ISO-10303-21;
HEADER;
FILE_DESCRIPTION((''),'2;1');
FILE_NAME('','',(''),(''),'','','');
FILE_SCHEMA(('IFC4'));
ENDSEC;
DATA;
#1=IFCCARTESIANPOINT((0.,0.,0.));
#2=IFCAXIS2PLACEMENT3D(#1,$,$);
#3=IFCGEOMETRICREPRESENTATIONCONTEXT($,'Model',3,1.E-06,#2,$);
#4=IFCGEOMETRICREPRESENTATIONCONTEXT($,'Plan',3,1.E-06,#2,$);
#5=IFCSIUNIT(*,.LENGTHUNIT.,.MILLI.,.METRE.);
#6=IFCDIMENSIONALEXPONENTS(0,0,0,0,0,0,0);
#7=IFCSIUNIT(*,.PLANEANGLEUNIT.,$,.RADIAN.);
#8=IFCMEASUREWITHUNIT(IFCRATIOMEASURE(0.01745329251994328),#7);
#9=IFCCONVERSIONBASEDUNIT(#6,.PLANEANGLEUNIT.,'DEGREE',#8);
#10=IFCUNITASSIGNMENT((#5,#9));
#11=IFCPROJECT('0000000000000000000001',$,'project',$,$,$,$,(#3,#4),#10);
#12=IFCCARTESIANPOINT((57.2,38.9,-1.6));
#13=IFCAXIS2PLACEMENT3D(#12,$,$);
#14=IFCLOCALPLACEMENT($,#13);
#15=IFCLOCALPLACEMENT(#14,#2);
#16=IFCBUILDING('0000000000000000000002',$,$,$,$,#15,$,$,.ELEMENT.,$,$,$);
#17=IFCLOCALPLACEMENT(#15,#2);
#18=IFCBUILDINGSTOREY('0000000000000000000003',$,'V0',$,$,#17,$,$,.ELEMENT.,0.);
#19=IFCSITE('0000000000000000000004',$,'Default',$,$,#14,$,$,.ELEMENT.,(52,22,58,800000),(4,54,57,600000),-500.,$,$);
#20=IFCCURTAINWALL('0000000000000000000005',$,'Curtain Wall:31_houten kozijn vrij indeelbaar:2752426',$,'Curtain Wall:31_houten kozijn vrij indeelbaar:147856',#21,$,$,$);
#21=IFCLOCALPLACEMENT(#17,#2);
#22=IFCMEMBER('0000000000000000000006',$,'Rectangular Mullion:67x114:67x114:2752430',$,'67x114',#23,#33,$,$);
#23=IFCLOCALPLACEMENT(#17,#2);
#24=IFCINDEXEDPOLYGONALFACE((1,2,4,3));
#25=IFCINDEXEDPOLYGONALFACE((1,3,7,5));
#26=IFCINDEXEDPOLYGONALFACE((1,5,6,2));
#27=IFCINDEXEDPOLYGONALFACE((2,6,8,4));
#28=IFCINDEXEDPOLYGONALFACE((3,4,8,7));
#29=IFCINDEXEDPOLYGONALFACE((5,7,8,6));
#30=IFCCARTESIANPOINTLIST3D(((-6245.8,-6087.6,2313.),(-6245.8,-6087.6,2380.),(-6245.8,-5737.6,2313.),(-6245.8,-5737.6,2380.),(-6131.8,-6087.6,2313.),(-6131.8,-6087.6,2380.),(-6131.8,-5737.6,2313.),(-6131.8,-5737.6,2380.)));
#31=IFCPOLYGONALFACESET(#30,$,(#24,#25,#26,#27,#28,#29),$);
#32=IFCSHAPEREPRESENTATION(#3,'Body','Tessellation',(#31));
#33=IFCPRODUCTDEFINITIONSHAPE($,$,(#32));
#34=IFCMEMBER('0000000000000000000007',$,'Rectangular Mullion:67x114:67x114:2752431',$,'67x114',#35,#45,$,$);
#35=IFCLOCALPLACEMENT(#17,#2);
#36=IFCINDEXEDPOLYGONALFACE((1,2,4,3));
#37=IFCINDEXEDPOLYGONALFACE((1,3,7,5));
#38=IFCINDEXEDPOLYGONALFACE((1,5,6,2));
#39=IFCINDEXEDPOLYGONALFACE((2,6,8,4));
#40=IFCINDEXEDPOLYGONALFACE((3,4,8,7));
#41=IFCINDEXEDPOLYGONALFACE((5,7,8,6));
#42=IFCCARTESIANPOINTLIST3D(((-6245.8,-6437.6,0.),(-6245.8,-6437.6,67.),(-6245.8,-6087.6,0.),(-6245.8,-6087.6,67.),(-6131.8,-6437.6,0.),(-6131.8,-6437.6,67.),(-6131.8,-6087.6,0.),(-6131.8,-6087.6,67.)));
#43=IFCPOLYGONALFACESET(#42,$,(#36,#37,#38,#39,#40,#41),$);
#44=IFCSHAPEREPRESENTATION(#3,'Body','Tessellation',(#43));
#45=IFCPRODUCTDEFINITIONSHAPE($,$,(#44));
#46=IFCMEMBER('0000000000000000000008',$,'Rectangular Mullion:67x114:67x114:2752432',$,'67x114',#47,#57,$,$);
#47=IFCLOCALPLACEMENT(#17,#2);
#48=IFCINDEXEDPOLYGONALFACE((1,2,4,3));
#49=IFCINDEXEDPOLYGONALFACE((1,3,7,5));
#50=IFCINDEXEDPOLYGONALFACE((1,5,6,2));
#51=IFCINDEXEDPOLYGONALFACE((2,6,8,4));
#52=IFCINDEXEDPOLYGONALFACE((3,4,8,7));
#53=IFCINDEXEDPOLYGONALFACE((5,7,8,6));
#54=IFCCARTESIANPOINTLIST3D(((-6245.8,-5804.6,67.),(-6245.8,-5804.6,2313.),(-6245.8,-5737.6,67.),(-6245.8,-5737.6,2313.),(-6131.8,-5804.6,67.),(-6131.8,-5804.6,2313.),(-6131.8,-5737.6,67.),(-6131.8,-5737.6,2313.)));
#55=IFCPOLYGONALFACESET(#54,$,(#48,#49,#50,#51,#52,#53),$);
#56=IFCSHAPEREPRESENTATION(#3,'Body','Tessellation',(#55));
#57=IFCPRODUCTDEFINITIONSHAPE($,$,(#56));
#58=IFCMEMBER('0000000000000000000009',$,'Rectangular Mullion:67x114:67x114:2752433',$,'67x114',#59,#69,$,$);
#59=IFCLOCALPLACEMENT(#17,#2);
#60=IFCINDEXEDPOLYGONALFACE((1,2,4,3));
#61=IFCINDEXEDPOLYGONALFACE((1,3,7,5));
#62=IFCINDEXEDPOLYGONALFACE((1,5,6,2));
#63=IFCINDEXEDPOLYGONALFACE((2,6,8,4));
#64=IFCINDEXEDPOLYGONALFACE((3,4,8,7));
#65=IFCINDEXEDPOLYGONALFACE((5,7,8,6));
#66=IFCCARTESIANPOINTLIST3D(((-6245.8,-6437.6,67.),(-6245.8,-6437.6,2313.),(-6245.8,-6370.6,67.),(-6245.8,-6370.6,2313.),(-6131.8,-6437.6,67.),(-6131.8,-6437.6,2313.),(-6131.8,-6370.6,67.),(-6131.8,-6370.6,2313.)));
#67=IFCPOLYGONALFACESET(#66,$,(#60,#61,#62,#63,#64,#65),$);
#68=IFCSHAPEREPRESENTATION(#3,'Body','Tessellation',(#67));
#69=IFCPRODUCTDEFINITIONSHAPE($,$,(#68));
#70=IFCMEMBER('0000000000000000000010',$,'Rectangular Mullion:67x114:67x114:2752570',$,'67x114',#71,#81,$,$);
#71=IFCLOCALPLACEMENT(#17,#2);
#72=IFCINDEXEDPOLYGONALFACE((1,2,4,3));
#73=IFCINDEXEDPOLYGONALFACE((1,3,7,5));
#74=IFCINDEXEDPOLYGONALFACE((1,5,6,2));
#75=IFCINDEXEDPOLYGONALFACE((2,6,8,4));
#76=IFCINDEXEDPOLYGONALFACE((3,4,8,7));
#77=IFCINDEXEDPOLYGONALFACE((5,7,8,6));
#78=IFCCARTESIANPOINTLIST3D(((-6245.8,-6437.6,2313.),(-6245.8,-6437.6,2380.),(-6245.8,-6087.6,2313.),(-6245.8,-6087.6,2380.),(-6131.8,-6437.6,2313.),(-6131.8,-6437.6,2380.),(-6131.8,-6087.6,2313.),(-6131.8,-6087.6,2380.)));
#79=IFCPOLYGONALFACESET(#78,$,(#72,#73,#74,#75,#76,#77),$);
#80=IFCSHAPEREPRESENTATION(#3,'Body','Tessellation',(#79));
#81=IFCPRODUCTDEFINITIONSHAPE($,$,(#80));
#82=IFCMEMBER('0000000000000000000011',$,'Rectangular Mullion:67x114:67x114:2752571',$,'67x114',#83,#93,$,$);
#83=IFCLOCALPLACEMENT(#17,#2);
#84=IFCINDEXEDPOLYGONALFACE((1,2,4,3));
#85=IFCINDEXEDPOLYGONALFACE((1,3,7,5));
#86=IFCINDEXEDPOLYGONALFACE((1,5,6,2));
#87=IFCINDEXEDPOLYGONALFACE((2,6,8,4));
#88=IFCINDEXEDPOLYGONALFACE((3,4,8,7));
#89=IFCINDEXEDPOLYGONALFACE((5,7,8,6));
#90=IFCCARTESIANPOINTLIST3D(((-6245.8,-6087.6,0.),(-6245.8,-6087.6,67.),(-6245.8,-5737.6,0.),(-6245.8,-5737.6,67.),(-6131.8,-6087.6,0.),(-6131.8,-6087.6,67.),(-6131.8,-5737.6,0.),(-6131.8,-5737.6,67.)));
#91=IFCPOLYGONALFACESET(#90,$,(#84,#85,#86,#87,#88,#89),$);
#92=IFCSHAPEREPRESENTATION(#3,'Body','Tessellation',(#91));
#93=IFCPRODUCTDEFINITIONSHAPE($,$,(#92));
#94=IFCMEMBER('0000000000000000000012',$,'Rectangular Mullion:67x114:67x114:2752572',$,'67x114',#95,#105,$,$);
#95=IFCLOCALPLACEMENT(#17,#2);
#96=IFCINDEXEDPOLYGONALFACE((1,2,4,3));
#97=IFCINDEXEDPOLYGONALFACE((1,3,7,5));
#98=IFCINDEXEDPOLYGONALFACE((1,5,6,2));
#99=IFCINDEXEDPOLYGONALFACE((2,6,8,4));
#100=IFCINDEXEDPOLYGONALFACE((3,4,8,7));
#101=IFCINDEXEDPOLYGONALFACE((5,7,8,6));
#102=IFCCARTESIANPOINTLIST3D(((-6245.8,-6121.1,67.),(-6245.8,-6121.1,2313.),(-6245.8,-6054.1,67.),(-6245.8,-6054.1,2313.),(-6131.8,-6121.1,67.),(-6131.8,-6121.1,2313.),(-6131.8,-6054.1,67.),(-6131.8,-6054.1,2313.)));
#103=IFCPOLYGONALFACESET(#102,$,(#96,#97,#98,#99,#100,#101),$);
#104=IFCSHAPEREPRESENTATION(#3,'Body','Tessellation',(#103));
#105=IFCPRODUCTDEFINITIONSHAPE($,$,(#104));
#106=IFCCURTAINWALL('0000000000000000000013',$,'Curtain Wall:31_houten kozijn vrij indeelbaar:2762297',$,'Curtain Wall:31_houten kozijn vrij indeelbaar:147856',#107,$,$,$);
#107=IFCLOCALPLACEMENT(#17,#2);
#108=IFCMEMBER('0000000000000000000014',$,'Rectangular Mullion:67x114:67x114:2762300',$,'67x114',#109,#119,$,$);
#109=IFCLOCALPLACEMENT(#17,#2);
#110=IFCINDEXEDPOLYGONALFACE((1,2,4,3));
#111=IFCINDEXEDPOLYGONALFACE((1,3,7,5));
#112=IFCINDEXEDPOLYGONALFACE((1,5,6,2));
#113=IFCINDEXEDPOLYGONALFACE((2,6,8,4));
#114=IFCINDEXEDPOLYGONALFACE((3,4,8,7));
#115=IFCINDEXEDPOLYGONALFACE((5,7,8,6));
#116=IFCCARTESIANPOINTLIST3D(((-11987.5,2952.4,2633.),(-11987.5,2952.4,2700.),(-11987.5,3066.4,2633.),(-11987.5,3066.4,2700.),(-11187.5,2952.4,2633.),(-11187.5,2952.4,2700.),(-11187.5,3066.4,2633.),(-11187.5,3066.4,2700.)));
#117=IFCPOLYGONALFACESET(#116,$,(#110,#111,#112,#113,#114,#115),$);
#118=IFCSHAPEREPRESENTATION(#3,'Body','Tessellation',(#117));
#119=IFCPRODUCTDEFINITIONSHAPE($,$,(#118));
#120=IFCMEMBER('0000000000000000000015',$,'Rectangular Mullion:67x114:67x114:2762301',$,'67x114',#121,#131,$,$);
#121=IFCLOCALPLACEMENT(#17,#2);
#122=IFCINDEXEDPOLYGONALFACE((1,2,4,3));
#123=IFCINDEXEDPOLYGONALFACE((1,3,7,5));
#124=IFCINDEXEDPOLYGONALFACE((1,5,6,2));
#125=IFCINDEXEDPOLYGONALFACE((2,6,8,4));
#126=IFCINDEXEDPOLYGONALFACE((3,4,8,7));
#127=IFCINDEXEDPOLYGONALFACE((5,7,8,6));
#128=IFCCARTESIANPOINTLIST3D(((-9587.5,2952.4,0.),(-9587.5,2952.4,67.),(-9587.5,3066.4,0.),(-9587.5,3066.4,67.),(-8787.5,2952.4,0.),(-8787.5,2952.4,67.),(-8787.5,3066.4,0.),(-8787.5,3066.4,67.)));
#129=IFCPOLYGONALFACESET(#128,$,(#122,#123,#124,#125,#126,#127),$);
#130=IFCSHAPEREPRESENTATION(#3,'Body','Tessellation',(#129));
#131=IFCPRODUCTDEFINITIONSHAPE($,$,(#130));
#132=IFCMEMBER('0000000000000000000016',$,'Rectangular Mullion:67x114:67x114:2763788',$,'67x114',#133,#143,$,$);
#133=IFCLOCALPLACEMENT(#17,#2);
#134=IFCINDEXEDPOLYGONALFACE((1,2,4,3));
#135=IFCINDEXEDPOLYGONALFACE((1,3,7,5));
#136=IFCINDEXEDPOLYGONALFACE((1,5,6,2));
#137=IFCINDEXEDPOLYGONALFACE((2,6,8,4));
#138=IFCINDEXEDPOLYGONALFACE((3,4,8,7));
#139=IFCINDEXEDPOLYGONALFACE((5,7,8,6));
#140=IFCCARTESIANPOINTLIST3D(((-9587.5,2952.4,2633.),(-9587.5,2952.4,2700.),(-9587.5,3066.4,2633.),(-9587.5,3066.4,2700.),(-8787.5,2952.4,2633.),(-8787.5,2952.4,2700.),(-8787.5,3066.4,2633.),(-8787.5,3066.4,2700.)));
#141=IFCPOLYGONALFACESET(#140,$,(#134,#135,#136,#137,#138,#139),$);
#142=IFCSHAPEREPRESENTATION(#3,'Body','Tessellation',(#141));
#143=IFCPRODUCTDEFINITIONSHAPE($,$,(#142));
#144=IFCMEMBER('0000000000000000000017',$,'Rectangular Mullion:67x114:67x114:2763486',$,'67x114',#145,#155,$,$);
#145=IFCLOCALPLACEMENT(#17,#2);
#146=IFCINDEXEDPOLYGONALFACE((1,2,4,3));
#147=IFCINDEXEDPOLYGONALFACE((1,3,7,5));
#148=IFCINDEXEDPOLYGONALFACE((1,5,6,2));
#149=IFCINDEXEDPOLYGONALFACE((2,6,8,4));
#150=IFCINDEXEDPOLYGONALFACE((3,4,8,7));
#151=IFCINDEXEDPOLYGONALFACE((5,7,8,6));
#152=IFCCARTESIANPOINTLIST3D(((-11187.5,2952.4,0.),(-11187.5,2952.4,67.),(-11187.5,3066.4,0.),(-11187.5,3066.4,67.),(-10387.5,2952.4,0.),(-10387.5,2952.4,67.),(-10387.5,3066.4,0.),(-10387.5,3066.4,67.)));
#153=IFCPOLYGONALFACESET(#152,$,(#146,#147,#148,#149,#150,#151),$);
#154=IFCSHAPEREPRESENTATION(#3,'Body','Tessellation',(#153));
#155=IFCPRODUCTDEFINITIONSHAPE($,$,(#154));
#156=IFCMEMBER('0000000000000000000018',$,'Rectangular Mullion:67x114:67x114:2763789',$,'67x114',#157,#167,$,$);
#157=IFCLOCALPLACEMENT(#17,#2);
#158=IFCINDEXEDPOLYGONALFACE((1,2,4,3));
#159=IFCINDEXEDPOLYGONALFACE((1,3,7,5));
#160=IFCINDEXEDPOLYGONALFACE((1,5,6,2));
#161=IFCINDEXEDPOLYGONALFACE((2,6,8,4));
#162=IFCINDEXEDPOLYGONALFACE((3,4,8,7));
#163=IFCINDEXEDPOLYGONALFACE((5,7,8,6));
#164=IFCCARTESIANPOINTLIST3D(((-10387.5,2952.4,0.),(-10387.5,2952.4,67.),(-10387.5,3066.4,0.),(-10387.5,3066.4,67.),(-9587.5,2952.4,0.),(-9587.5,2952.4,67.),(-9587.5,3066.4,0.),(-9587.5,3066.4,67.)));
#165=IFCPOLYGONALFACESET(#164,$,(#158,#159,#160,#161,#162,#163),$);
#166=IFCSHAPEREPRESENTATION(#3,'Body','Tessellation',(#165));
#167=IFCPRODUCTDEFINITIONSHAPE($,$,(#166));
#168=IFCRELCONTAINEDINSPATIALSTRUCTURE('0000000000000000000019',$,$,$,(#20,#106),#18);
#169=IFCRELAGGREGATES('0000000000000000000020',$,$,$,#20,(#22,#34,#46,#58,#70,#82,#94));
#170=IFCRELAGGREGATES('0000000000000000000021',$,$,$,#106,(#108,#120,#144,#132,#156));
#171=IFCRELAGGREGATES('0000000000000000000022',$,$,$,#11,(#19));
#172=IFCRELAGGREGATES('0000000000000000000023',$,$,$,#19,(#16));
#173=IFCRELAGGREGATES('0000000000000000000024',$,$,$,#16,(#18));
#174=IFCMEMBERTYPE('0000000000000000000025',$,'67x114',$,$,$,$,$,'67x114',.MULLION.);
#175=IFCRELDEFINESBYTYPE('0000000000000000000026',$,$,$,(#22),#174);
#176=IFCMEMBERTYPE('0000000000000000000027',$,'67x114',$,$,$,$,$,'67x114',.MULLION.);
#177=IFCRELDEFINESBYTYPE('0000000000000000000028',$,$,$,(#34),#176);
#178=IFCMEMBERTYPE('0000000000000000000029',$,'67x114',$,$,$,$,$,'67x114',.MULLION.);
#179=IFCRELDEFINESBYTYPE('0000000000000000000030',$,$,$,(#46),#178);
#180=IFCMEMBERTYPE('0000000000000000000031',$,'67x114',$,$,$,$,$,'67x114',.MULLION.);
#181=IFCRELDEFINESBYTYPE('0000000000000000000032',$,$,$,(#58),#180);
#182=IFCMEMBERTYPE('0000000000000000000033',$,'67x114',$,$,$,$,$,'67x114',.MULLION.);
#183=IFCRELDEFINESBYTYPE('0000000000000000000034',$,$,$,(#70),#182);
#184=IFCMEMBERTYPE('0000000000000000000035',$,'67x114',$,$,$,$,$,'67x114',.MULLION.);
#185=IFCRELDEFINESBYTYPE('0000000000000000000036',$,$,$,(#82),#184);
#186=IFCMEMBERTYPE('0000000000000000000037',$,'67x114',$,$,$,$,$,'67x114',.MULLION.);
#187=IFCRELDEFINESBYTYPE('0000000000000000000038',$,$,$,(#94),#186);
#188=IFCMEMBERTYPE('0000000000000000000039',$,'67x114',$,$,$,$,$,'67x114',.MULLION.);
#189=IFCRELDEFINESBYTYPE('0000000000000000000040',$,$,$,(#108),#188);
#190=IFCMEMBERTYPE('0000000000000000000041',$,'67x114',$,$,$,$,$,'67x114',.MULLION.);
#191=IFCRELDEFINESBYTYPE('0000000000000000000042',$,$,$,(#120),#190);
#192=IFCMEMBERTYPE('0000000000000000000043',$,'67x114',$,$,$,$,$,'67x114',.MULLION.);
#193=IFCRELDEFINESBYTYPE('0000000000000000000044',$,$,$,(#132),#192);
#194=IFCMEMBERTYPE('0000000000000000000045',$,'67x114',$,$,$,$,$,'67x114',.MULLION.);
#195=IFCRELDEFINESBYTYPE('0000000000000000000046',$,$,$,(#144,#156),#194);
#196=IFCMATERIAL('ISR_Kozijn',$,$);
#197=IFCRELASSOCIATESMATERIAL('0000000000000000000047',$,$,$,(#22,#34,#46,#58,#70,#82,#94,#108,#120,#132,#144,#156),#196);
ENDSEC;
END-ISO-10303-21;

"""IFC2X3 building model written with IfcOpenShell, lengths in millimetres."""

from ifc_helpers import new_model, entity, si_unit, converted_unit, frame, origin, origin_2d_with_axis, place, context, project, spatial, rectangle, extrude, source, transform, mapped, material, type_object, type_shapes, element, aggregate, save


model = new_model("IFC2X3")

# Units and contexts
model_context = context("Model", 3, precision=1e-06, world=origin())
plan_context = context("Plan", 3, precision=1e-06, world=origin())
ifc_project = project(units=[si_unit("LENGTHUNIT", "METRE", prefix="MILLI"), converted_unit("PLANEANGLEUNIT", "DEGREE", entity("IfcRatioMeasure", 0.01745329251994328), si_unit("PLANEANGLEUNIT", "RADIAN"), dimensions=[0, 0, 0, 0, 0, 0, 0])], contexts=[model_context, plan_context])

# Site, building, storey
site_placement = place(None, frame((57.2, 38.9, -1.6)))
site = spatial("IfcSite", under=ifc_project, at=site_placement, Name="Default", CompositionType="ELEMENT", RefLatitude=(52, 22, 58, 800000), RefLongitude=(4, 54, 57, 600000), RefElevation=-500.0)
building_placement = place(site_placement, origin())
building = spatial("IfcBuilding", under=site, at=building_placement, CompositionType="ELEMENT")
storey_placement = place(building_placement, origin())
storey = spatial("IfcBuildingStorey", under=building, at=storey_placement, Name="V0", CompositionType="ELEMENT", Elevation=0.0)

# Curtain walls, members
curtain_wall_1_placement = place(storey_placement, origin())
curtain_wall_1 = element("IfcCurtainWall", 1, at=curtain_wall_1_placement, inside=storey, Name="Curtain Wall:31_houten kozijn vrij indeelbaar:2752426", ObjectType="Curtain Wall:31_houten kozijn vrij indeelbaar:147856")
ifc_material_1 = material(Name="ISR_Kozijn")
member_type_1 = type_object("IfcMemberType", Name="67x114", ElementType="67x114", PredefinedType="MULLION")
shared_shape_1 = source(origin(), model_context, "Body", "SweptSolid", [
    extrude(rectangle(XDim=67.0, YDim=114.0, at=origin_2d_with_axis()), frame((-33.5, 57.0, -350.0), z_axis=(0.0, 0.0, 1.0), x_axis=(-1.0, 0.0, 0.0)), (0.0, 0.0, 1.0), 350.0),
])
type_shapes(member_type_1, [shared_shape_1])
placement_1 = place(building_placement, frame((0.0, 0.0, 625.0)))
member_1_placement = place(placement_1, frame((-6245.8, -5737.6, 1755.0), z_axis=(0.0, 1.0, 0.0), x_axis=(0.0, 0.0, 1.0)))
member_1 = element("IfcMember", 2, at=member_1_placement, type_object=member_type_1, material=ifc_material_1, Name="Rectangular Mullion:67x114:67x114:2752430", ObjectType="67x114", context=model_context, shape_type="MappedRepresentation", body=[
    mapped(shared_shape_1, transform((0.0, 0.0, 0.0), scale=1.0)),
])
member_type_2 = type_object("IfcMemberType", Name="67x114", ElementType="67x114", PredefinedType="MULLION")
shared_shape_2 = source(origin(), model_context, "Body", "SweptSolid", [
    extrude(rectangle(XDim=67.0, YDim=114.0, at=origin_2d_with_axis()), frame((-33.5, 57.0, -350.0), z_axis=(0.0, 0.0, 1.0), x_axis=(-1.0, 0.0, 0.0)), (0.0, 0.0, 1.0), 350.0),
])
type_shapes(member_type_2, [shared_shape_2])
placement_2 = place(building_placement, origin())
member_2_placement = place(placement_2, frame((-6245.8, -6437.6, 0.0), z_axis=(0.0, -1.0, 0.0), x_axis=(0.0, 0.0, -1.0)))
member_2 = element("IfcMember", 3, at=member_2_placement, type_object=member_type_2, material=ifc_material_1, Name="Rectangular Mullion:67x114:67x114:2752431", ObjectType="67x114", context=model_context, shape_type="MappedRepresentation", body=[
    mapped(shared_shape_2, transform((0.0, 0.0, 0.0), scale=1.0)),
])
member_type_3 = type_object("IfcMemberType", Name="67x114", ElementType="67x114", PredefinedType="MULLION")
shared_shape_3 = source(origin(), model_context, "Body", "SweptSolid", [
    extrude(rectangle(XDim=67.0, YDim=114.0, at=origin_2d_with_axis()), frame((-33.5, 57.0, -2246.0), z_axis=(0.0, 0.0, 1.0), x_axis=(-1.0, 0.0, 0.0)), (0.0, 0.0, 1.0), 2246.0),
])
type_shapes(member_type_3, [shared_shape_3])
member_3_placement = place(placement_2, frame((-6245.8, -5737.6, 67.0), z_axis=(0.0, 0.0, -1.0), x_axis=(0.0, 1.0, 0.0)))
member_3 = element("IfcMember", 4, at=member_3_placement, type_object=member_type_3, material=ifc_material_1, Name="Rectangular Mullion:67x114:67x114:2752432", ObjectType="67x114", context=model_context, shape_type="MappedRepresentation", body=[
    mapped(shared_shape_3, transform((0.0, 0.0, 0.0), scale=1.0)),
])
member_type_4 = type_object("IfcMemberType", Name="67x114", ElementType="67x114", PredefinedType="MULLION")
shared_shape_4 = source(origin(), model_context, "Body", "SweptSolid", [
    extrude(rectangle(XDim=67.0, YDim=114.0, at=origin_2d_with_axis()), frame((-33.5, 57.0, -2246.0), z_axis=(0.0, 0.0, 1.0), x_axis=(-1.0, 0.0, 0.0)), (0.0, 0.0, 1.0), 2246.0),
])
type_shapes(member_type_4, [shared_shape_4])
member_4_placement = place(placement_2, frame((-6245.8, -6437.6, 2313.0), z_axis=(0.0, 0.0, 1.0), x_axis=(0.0, -1.0, 0.0)))
member_4 = element("IfcMember", 5, at=member_4_placement, type_object=member_type_4, material=ifc_material_1, Name="Rectangular Mullion:67x114:67x114:2752433", ObjectType="67x114", context=model_context, shape_type="MappedRepresentation", body=[
    mapped(shared_shape_4, transform((0.0, 0.0, 0.0), scale=1.0)),
])
member_type_5 = type_object("IfcMemberType", Name="67x114", ElementType="67x114", PredefinedType="MULLION")
shared_shape_5 = source(origin(), model_context, "Body", "SweptSolid", [
    extrude(rectangle(XDim=67.0, YDim=114.0, at=origin_2d_with_axis()), frame((-33.5, 57.0, -350.0), z_axis=(0.0, 0.0, 1.0), x_axis=(-1.0, 0.0, 0.0)), (0.0, 0.0, 1.0), 350.0),
])
type_shapes(member_type_5, [shared_shape_5])
member_5_placement = place(placement_1, frame((-6245.8, -6087.6, 1755.0), z_axis=(0.0, 1.0, 0.0), x_axis=(0.0, 0.0, 1.0)))
member_5 = element("IfcMember", 6, at=member_5_placement, type_object=member_type_5, material=ifc_material_1, Name="Rectangular Mullion:67x114:67x114:2752570", ObjectType="67x114", context=model_context, shape_type="MappedRepresentation", body=[
    mapped(shared_shape_5, transform((0.0, 0.0, 0.0), scale=1.0)),
])
member_type_6 = type_object("IfcMemberType", Name="67x114", ElementType="67x114", PredefinedType="MULLION")
shared_shape_6 = source(origin(), model_context, "Body", "SweptSolid", [
    extrude(rectangle(XDim=67.0, YDim=114.0, at=origin_2d_with_axis()), frame((-33.5, 57.0, -350.0), z_axis=(0.0, 0.0, 1.0), x_axis=(-1.0, 0.0, 0.0)), (0.0, 0.0, 1.0), 350.0),
])
type_shapes(member_type_6, [shared_shape_6])
member_6_placement = place(placement_2, frame((-6245.8, -6087.6, 0.0), z_axis=(0.0, -1.0, 0.0), x_axis=(0.0, 0.0, -1.0)))
member_6 = element("IfcMember", 7, at=member_6_placement, type_object=member_type_6, material=ifc_material_1, Name="Rectangular Mullion:67x114:67x114:2752571", ObjectType="67x114", context=model_context, shape_type="MappedRepresentation", body=[
    mapped(shared_shape_6, transform((0.0, 0.0, 0.0), scale=1.0)),
])
member_type_7 = type_object("IfcMemberType", Name="67x114", ElementType="67x114", PredefinedType="MULLION")
shared_shape_7 = source(origin(), model_context, "Body", "SweptSolid", [
    extrude(rectangle(XDim=67.0, YDim=114.0, at=origin_2d_with_axis()), frame((0.0, 57.0, -2246.0), z_axis=(0.0, 0.0, 1.0), x_axis=(-1.0, 0.0, 0.0)), (0.0, 0.0, 1.0), 2246.0),
])
type_shapes(member_type_7, [shared_shape_7])
member_7_placement = place(placement_2, frame((-6245.8, -6087.6, 67.0), z_axis=(0.0, 0.0, -1.0), x_axis=(0.0, 1.0, 0.0)))
member_7 = element("IfcMember", 8, at=member_7_placement, type_object=member_type_7, material=ifc_material_1, Name="Rectangular Mullion:67x114:67x114:2752572", ObjectType="67x114", context=model_context, shape_type="MappedRepresentation", body=[
    mapped(shared_shape_7, transform((0.0, 0.0, 0.0), scale=1.0)),
])
curtain_wall_2_placement = place(storey_placement, origin())
curtain_wall_2 = element("IfcCurtainWall", 9, at=curtain_wall_2_placement, inside=storey, Name="Curtain Wall:31_houten kozijn vrij indeelbaar:2762297", ObjectType="Curtain Wall:31_houten kozijn vrij indeelbaar:147856")
member_type_8 = type_object("IfcMemberType", Name="67x114", ElementType="67x114", PredefinedType="MULLION")
shared_shape_8 = source(origin(), model_context, "Body", "SweptSolid", [
    extrude(rectangle(XDim=67.0, YDim=114.0, at=origin_2d_with_axis()), frame((-33.5, 57.0, -800.0), z_axis=(0.0, 0.0, 1.0), x_axis=(-1.0, 0.0, 0.0)), (0.0, 0.0, 1.0), 800.0),
])
type_shapes(member_type_8, [shared_shape_8])
placement_3 = place(building_placement, frame((0.0, 0.0, 2425.0)))
member_8_placement = place(placement_3, frame((-11987.5, 2952.4, 275.0), z_axis=(-1.0, 0.0, 0.0), x_axis=(0.0, 0.0, 1.0)))
member_8 = element("IfcMember", 10, at=member_8_placement, type_object=member_type_8, material=ifc_material_1, Name="Rectangular Mullion:67x114:67x114:2762300", ObjectType="67x114", context=model_context, shape_type="MappedRepresentation", body=[
    mapped(shared_shape_8, transform((0.0, 0.0, 0.0), scale=1.0)),
])
member_type_9 = type_object("IfcMemberType", Name="67x114", ElementType="67x114", PredefinedType="MULLION")
shared_shape_9 = source(origin(), model_context, "Body", "SweptSolid", [
    extrude(rectangle(XDim=67.0, YDim=114.0, at=origin_2d_with_axis()), frame((-33.5, 57.0, -800.0), z_axis=(0.0, 0.0, 1.0), x_axis=(-1.0, 0.0, 0.0)), (0.0, 0.0, 1.0), 800.0),
])
type_shapes(member_type_9, [shared_shape_9])
member_9_placement = place(placement_2, frame((-8787.5, 2952.4, 0.0), z_axis=(1.0, 0.0, 0.0), x_axis=(0.0, 0.0, -1.0)))
member_9 = element("IfcMember", 11, at=member_9_placement, type_object=member_type_9, material=ifc_material_1, Name="Rectangular Mullion:67x114:67x114:2762301", ObjectType="67x114", context=model_context, shape_type="MappedRepresentation", body=[
    mapped(shared_shape_9, transform((0.0, 0.0, 0.0), scale=1.0)),
])
member_type_10 = type_object("IfcMemberType", Name="67x114", ElementType="67x114", PredefinedType="MULLION")
shared_shape_10 = source(origin(), model_context, "Body", "SweptSolid", [
    extrude(rectangle(XDim=67.0, YDim=114.0, at=origin_2d_with_axis()), frame((-33.5, 57.0, -800.0), z_axis=(0.0, 0.0, 1.0), x_axis=(-1.0, 0.0, 0.0)), (0.0, 0.0, 1.0), 800.0),
])
type_shapes(member_type_10, [shared_shape_10])
member_10_placement = place(placement_3, frame((-9587.5, 2952.4, 275.0), z_axis=(-1.0, 0.0, 0.0), x_axis=(0.0, 0.0, 1.0)))
member_10 = element("IfcMember", 12, at=member_10_placement, type_object=member_type_10, material=ifc_material_1, Name="Rectangular Mullion:67x114:67x114:2763788", ObjectType="67x114", context=model_context, shape_type="MappedRepresentation", body=[
    mapped(shared_shape_10, transform((0.0, 0.0, 0.0), scale=1.0)),
])
member_type_11 = type_object("IfcMemberType", Name="67x114", ElementType="67x114", PredefinedType="MULLION")
shared_shape_11 = source(origin(), model_context, "Body", "SweptSolid", [
    extrude(rectangle(XDim=67.0, YDim=114.0, at=origin_2d_with_axis()), frame((-33.5, 57.0, -800.0), z_axis=(0.0, 0.0, 1.0), x_axis=(-1.0, 0.0, 0.0)), (0.0, 0.0, 1.0), 800.0),
])
type_shapes(member_type_11, [shared_shape_11])
member_11_placement = place(placement_2, frame((-10387.5, 2952.4, 0.0), z_axis=(1.0, 0.0, 0.0), x_axis=(0.0, 0.0, -1.0)))
member_11 = element("IfcMember", 13, at=member_11_placement, type_object=member_type_11, material=ifc_material_1, Name="Rectangular Mullion:67x114:67x114:2763486", ObjectType="67x114", context=model_context, shape_type="MappedRepresentation", body=[
    mapped(shared_shape_11, transform((0.0, 0.0, 0.0), scale=1.0)),
])
member_12_placement = place(placement_2, frame((-9587.5, 2952.4, 0.0), z_axis=(1.0, 0.0, 0.0), x_axis=(0.0, 0.0, -1.0)))
member_12 = element("IfcMember", 14, at=member_12_placement, type_object=member_type_11, material=ifc_material_1, Name="Rectangular Mullion:67x114:67x114:2763789", ObjectType="67x114", context=model_context, shape_type="MappedRepresentation", body=[
    mapped(shared_shape_11, transform((0.0, 0.0, 0.0), scale=1.0)),
])

aggregate(curtain_wall_1, [member_1, member_2, member_3, member_4, member_5, member_6, member_7])

aggregate(curtain_wall_2, [member_8, member_9, member_11, member_10, member_12])

save(model, "model.ifc")
